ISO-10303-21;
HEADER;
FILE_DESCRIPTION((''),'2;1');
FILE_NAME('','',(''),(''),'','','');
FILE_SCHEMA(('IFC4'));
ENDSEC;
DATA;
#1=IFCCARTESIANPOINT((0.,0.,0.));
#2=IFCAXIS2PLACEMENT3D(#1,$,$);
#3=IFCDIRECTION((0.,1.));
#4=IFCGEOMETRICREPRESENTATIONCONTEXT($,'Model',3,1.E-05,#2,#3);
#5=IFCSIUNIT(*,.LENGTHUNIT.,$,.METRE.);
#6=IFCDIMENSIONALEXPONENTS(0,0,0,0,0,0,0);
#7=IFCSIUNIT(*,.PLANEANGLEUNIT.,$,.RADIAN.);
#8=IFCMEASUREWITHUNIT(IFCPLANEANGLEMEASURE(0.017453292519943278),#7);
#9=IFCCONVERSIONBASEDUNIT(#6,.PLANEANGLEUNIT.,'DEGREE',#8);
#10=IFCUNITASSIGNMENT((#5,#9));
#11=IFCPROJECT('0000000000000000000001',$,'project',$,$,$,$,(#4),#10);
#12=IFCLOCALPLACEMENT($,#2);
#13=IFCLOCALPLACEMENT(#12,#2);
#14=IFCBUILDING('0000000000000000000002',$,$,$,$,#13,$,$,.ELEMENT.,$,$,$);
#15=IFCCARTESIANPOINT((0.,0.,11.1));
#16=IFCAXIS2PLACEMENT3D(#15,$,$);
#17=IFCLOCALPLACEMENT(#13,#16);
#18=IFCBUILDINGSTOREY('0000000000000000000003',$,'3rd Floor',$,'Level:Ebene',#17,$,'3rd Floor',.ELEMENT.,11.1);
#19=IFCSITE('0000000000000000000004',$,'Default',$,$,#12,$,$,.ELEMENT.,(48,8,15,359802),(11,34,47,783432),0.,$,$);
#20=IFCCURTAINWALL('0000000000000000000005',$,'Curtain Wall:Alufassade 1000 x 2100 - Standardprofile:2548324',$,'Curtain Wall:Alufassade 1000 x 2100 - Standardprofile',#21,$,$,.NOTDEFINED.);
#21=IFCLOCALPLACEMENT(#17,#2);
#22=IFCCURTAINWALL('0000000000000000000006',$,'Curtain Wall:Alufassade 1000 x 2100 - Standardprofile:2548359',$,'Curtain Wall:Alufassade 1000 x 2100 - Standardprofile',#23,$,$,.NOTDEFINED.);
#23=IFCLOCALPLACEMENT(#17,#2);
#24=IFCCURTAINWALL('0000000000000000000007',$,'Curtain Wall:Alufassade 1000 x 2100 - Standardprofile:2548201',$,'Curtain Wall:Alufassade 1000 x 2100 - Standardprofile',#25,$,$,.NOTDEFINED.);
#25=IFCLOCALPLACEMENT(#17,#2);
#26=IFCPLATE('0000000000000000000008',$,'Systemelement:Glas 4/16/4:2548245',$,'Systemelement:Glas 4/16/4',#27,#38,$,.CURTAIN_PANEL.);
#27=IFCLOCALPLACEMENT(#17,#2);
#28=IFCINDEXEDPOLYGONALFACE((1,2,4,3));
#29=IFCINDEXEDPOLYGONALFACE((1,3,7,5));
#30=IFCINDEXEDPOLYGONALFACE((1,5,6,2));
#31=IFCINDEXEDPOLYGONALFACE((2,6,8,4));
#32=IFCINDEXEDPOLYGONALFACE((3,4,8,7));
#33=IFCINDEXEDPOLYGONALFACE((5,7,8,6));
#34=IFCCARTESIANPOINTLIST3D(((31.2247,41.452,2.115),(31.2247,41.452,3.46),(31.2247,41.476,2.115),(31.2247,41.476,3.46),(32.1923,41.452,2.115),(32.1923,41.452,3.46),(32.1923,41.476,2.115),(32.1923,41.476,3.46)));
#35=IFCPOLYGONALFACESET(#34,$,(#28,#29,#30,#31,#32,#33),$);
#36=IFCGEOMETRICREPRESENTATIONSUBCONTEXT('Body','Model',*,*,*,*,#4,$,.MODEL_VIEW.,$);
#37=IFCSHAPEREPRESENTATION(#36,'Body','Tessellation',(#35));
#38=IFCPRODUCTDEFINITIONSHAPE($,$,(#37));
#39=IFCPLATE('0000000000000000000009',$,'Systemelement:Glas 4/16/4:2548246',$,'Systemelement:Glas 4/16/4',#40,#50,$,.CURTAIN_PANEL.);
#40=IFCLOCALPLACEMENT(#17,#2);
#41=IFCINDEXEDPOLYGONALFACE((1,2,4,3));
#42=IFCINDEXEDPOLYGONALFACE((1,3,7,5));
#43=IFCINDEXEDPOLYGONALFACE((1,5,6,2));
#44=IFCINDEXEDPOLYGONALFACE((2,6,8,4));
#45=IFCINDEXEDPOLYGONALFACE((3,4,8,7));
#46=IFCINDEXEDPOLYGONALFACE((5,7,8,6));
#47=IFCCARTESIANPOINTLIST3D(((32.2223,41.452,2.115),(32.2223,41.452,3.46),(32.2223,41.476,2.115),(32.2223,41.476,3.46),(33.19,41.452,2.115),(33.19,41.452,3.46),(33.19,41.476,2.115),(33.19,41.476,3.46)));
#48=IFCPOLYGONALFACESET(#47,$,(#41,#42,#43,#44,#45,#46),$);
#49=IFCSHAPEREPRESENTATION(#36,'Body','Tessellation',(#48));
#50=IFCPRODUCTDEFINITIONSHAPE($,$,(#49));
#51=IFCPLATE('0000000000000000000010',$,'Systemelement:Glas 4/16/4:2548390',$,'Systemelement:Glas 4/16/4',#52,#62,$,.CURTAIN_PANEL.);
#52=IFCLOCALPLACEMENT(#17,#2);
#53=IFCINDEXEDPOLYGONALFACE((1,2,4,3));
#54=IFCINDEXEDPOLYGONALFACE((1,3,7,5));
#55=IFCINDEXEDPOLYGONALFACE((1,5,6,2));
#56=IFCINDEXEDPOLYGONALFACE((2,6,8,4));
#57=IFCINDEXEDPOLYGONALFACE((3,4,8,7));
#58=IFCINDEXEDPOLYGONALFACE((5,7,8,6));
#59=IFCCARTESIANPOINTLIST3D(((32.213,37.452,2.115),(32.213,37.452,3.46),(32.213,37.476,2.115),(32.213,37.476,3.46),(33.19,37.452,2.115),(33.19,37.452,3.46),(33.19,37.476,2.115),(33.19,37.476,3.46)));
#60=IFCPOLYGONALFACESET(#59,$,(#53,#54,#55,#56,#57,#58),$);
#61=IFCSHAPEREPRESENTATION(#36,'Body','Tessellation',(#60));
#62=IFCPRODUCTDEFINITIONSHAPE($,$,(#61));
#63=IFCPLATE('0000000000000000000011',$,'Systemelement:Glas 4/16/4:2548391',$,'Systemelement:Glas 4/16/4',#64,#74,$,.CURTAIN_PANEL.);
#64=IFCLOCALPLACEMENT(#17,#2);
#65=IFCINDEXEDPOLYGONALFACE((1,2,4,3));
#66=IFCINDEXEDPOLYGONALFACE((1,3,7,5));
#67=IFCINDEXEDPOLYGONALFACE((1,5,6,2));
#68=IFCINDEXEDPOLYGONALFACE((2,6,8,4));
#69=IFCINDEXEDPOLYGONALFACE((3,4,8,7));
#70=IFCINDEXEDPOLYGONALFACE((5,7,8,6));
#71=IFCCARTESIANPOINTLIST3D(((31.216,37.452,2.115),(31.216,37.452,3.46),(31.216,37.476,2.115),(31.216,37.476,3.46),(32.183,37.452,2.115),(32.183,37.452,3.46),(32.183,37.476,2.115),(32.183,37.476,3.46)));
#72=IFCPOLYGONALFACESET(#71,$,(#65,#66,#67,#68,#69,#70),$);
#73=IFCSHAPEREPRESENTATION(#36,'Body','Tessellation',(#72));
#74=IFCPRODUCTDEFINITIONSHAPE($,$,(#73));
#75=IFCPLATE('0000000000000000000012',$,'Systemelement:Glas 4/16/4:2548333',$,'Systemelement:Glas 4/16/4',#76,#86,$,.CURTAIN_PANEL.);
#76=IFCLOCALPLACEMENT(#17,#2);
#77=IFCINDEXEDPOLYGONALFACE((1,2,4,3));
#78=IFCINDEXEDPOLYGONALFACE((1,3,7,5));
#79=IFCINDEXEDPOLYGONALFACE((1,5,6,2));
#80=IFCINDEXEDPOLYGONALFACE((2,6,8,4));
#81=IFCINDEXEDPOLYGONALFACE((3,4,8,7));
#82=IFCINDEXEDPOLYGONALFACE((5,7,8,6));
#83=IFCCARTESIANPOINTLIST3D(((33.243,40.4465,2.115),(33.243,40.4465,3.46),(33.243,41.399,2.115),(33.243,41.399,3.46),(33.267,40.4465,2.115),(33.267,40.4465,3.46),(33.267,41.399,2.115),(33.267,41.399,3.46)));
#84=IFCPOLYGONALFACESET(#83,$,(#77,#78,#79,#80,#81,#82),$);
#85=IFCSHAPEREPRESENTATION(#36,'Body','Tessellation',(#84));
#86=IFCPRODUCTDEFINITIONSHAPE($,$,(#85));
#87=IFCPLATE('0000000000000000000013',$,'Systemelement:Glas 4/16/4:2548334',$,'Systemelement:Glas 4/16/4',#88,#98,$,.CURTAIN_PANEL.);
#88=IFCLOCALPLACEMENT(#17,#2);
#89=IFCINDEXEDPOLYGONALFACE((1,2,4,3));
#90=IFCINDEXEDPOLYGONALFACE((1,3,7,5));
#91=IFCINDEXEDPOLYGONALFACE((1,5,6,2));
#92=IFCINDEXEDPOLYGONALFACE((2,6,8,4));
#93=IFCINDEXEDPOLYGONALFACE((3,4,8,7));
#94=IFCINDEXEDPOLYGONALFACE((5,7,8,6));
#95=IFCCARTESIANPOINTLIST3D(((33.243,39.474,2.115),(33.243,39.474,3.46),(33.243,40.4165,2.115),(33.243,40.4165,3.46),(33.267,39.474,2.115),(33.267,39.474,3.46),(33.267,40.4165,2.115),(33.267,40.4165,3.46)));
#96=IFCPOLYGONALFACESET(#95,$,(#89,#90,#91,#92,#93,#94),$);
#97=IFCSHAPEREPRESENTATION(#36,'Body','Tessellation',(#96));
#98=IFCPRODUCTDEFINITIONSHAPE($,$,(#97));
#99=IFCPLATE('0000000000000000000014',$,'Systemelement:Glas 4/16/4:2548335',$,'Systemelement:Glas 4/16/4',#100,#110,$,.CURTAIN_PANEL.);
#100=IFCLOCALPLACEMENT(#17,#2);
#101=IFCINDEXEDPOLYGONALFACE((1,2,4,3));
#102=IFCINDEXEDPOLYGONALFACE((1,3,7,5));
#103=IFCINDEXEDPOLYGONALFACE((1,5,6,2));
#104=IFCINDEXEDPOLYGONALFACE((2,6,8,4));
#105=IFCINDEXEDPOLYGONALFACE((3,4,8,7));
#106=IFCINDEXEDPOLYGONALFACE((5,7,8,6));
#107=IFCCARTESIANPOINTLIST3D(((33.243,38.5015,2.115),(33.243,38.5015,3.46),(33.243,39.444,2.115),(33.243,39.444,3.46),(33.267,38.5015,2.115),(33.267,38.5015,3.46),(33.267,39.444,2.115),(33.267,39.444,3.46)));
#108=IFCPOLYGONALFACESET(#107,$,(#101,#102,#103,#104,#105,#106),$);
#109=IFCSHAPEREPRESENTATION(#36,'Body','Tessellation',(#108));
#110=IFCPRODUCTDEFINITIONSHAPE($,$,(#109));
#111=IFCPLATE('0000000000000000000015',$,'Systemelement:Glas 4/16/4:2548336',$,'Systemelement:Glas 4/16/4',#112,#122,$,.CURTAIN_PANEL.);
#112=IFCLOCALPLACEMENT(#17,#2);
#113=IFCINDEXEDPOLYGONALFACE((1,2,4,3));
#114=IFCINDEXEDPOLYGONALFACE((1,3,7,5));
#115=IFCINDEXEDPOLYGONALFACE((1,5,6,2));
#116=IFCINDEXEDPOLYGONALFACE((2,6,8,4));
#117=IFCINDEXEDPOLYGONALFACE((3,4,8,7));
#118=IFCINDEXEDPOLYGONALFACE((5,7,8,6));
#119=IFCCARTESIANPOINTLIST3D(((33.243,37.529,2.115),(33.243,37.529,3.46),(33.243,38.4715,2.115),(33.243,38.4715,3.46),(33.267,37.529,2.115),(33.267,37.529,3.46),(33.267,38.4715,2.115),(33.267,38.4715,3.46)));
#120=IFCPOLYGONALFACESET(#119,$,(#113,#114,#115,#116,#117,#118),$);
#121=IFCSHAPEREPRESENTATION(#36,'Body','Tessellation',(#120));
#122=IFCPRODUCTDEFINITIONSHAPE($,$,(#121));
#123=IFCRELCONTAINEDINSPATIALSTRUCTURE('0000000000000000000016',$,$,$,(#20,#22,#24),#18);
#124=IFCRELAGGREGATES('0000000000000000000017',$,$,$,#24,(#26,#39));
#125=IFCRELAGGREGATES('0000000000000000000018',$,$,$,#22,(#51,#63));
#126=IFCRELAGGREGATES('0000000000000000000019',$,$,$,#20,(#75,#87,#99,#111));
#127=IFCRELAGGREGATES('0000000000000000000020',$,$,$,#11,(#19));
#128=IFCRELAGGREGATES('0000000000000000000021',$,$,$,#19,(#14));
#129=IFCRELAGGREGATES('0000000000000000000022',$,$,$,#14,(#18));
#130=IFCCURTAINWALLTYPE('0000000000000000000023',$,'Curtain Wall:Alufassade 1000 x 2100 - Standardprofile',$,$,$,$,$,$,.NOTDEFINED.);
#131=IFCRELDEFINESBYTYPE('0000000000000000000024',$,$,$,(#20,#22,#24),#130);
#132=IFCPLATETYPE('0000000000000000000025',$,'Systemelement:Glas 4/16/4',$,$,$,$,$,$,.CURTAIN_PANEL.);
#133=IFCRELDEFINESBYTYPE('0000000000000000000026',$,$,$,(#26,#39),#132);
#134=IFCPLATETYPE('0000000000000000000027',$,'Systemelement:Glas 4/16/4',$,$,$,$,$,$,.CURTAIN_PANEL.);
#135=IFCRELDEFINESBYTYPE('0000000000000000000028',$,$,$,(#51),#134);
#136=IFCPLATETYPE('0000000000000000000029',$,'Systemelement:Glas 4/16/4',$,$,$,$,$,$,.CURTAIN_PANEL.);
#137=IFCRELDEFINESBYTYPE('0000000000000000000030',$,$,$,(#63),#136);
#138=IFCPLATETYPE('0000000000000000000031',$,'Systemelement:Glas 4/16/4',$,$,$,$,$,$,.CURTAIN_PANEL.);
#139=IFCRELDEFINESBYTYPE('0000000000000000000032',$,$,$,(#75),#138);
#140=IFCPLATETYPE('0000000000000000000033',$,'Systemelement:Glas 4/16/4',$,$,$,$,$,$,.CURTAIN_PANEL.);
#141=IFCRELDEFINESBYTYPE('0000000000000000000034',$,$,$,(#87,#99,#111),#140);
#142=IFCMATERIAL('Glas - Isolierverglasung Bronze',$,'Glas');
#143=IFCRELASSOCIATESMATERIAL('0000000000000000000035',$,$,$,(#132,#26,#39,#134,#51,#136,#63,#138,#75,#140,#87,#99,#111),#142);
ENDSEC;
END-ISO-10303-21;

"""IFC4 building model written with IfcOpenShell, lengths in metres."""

from ifc_helpers import new_model, entity, si_unit, converted_unit, direction, frame, origin, place, context, subcontext, project, spatial, indexed_curve, outline, extrude, source, transform, mapped, material, type_object, type_shapes, element, aggregate, save


model = new_model("IFC4")

# Units and contexts
model_context = context("Model", 3, precision=1e-05, world=origin(), true_north=direction((0.0, 1.0)))
body_context = subcontext(model_context, "Body", "Model", "MODEL_VIEW")
ifc_project = project(units=[si_unit("LENGTHUNIT", "METRE"), converted_unit("PLANEANGLEUNIT", "DEGREE", entity("IfcPlaneAngleMeasure", 0.017453292519943278), si_unit("PLANEANGLEUNIT", "RADIAN"), dimensions=[0, 0, 0, 0, 0, 0, 0])], contexts=[model_context])

# Site, building, storey
site_placement = place(None, origin())
site = spatial("IfcSite", under=ifc_project, at=site_placement, Name="Default", CompositionType="ELEMENT", RefLatitude=(48, 8, 15, 359802), RefLongitude=(11, 34, 47, 783432), RefElevation=0.0)
building_placement = place(site_placement, origin())
building = spatial("IfcBuilding", under=site, at=building_placement, CompositionType="ELEMENT")
storey_placement = place(building_placement, frame((0.0, 0.0, 11.1)))
storey = spatial("IfcBuildingStorey", under=building, at=storey_placement, Name="3rd Floor", ObjectType="Level:Ebene", LongName="3rd Floor", CompositionType="ELEMENT", Elevation=11.1)

# Curtain walls
curtain_wall_type = type_object("IfcCurtainWallType", Name="Curtain Wall:Alufassade 1000 x 2100 - Standardprofile", PredefinedType="NOTDEFINED")
curtain_wall_1_placement = place(storey_placement, frame((0.0, 0.0, -11.1)))
curtain_wall_1 = element("IfcCurtainWall", 1, at=curtain_wall_1_placement, inside=storey, type_object=curtain_wall_type, Name="Curtain Wall:Alufassade 1000 x 2100 - Standardprofile:2548324", ObjectType="Curtain Wall:Alufassade 1000 x 2100 - Standardprofile", PredefinedType="NOTDEFINED")
curtain_wall_2_placement = place(storey_placement, frame((0.0, 0.0, -11.1)))
curtain_wall_2 = element("IfcCurtainWall", 2, at=curtain_wall_2_placement, inside=storey, type_object=curtain_wall_type, Name="Curtain Wall:Alufassade 1000 x 2100 - Standardprofile:2548359", ObjectType="Curtain Wall:Alufassade 1000 x 2100 - Standardprofile", PredefinedType="NOTDEFINED")

# Curtain wall
curtain_wall_3_placement = place(storey_placement, frame((0.0, 0.0, -11.1)))
curtain_wall_3 = element("IfcCurtainWall", 3, at=curtain_wall_3_placement, inside=storey, type_object=curtain_wall_type, Name="Curtain Wall:Alufassade 1000 x 2100 - Standardprofile:2548201", ObjectType="Curtain Wall:Alufassade 1000 x 2100 - Standardprofile", PredefinedType="NOTDEFINED")

# Plates
ifc_material_1 = material(Name="Glas - Isolierverglasung Bronze", Category="Glas")
plate_type_1 = type_object("IfcPlateType", Name="Systemelement:Glas 4/16/4", PredefinedType="CURTAIN_PANEL", material=ifc_material_1)
shared_shape_1 = source(origin(), body_context, "Body", "SweptSolid", [
    extrude(outline(indexed_curve([(-0.012, -0.4838), (0.012, -0.4838), (0.012, 0.4838), (-0.012, 0.4838), (-0.012, -0.4838)], self_intersect=False)), frame((0.0, 0.0, 0.0), z_axis=(0.0, 0.0, 1.0), x_axis=(0.0, 1.0, 0.0)), (0.0, 0.0, 1.0), 1.345),
])
type_shapes(plate_type_1, [shared_shape_1])
plate_1_placement = place(curtain_wall_3_placement, frame((31.7085, 41.464, 13.215)))
plate_1 = element("IfcPlate", 4, at=plate_1_placement, type_object=plate_type_1, material=ifc_material_1, Name="Systemelement:Glas 4/16/4:2548245", ObjectType="Systemelement:Glas 4/16/4", PredefinedType="CURTAIN_PANEL", context=body_context, shape_type="MappedRepresentation", body=[
    mapped(shared_shape_1, transform((0.0, 0.0, 0.0), scale=1.0)),
])
plate_2_placement = place(curtain_wall_3_placement, frame((32.7062, 41.464, 13.215)))
plate_2 = element("IfcPlate", 5, at=plate_2_placement, type_object=plate_type_1, material=ifc_material_1, Name="Systemelement:Glas 4/16/4:2548246", ObjectType="Systemelement:Glas 4/16/4", PredefinedType="CURTAIN_PANEL", context=body_context, shape_type="MappedRepresentation", body=[
    mapped(shared_shape_1, transform((0.0, 0.0, 0.0), scale=1.0)),
])
aggregate(curtain_wall_3, [plate_1, plate_2])
plate_type_2 = type_object("IfcPlateType", Name="Systemelement:Glas 4/16/4", PredefinedType="CURTAIN_PANEL", material=ifc_material_1)
shared_shape_2 = source(origin(), body_context, "Body", "SweptSolid", [
    extrude(outline(indexed_curve([(-0.012, -0.4885), (0.012, -0.4885), (0.012, 0.4885), (-0.012, 0.4885), (-0.012, -0.4885)], self_intersect=False)), frame((0.0, 0.0, 0.0), z_axis=(0.0, 0.0, 1.0), x_axis=(0.0, 1.0, 0.0)), (0.0, 0.0, 1.0), 1.345),
])
type_shapes(plate_type_2, [shared_shape_2])
plate_3_placement = place(curtain_wall_2_placement, frame((32.7015, 37.464, 13.215), z_axis=(0.0, 0.0, 1.0), x_axis=(-1.0, 0.0, 0.0)))
plate_3 = element("IfcPlate", 6, at=plate_3_placement, type_object=plate_type_2, material=ifc_material_1, Name="Systemelement:Glas 4/16/4:2548390", ObjectType="Systemelement:Glas 4/16/4", PredefinedType="CURTAIN_PANEL", context=body_context, shape_type="MappedRepresentation", body=[
    mapped(shared_shape_2, transform((0.0, 0.0, 0.0), scale=1.0)),
])
plate_type_3 = type_object("IfcPlateType", Name="Systemelement:Glas 4/16/4", PredefinedType="CURTAIN_PANEL", material=ifc_material_1)
shared_shape_3 = source(origin(), body_context, "Body", "SweptSolid", [
    extrude(outline(indexed_curve([(-0.012, -0.4835), (0.012, -0.4835), (0.012, 0.4835), (-0.012, 0.4835), (-0.012, -0.4835)], self_intersect=False)), frame((0.0, 0.0, 0.0), z_axis=(0.0, 0.0, 1.0), x_axis=(0.0, 1.0, 0.0)), (0.0, 0.0, 1.0), 1.345),
])
type_shapes(plate_type_3, [shared_shape_3])
plate_4_placement = place(curtain_wall_2_placement, frame((31.6995, 37.464, 13.215), z_axis=(0.0, 0.0, 1.0), x_axis=(-1.0, 0.0, 0.0)))
plate_4 = element("IfcPlate", 7, at=plate_4_placement, type_object=plate_type_3, material=ifc_material_1, Name="Systemelement:Glas 4/16/4:2548391", ObjectType="Systemelement:Glas 4/16/4", PredefinedType="CURTAIN_PANEL", context=body_context, shape_type="MappedRepresentation", body=[
    mapped(shared_shape_3, transform((0.0, 0.0, 0.0), scale=1.0)),
])
aggregate(curtain_wall_2, [plate_3, plate_4])
plate_type_4 = type_object("IfcPlateType", Name="Systemelement:Glas 4/16/4", PredefinedType="CURTAIN_PANEL", material=ifc_material_1)
shared_shape_4 = source(origin(), body_context, "Body", "SweptSolid", [
    extrude(outline(indexed_curve([(-0.012, -0.4763), (0.012, -0.4763), (0.012, 0.4763), (-0.012, 0.4763), (-0.012, -0.4763)], self_intersect=False)), frame((0.0, 0.0, 0.0), z_axis=(0.0, 0.0, 1.0), x_axis=(0.0, 1.0, 0.0)), (0.0, 0.0, 1.0), 1.345),
])
type_shapes(plate_type_4, [shared_shape_4])
plate_5_placement = place(curtain_wall_1_placement, frame((33.255, 40.9228, 13.215), z_axis=(0.0, 0.0, 1.0), x_axis=(0.0, -1.0, 0.0)))
plate_5 = element("IfcPlate", 8, at=plate_5_placement, type_object=plate_type_4, material=ifc_material_1, Name="Systemelement:Glas 4/16/4:2548333", ObjectType="Systemelement:Glas 4/16/4", PredefinedType="CURTAIN_PANEL", context=body_context, shape_type="MappedRepresentation", body=[
    mapped(shared_shape_4, transform((0.0, 0.0, 0.0), scale=1.0)),
])
plate_type_5 = type_object("IfcPlateType", Name="Systemelement:Glas 4/16/4", PredefinedType="CURTAIN_PANEL", material=ifc_material_1)
shared_shape_5 = source(origin(), body_context, "Body", "SweptSolid", [
    extrude(outline(indexed_curve([(-0.012, -0.4712), (0.012, -0.4712), (0.012, 0.4712), (-0.012, 0.4712), (-0.012, -0.4712)], self_intersect=False)), frame((0.0, 0.0, 0.0), z_axis=(0.0, 0.0, 1.0), x_axis=(0.0, 1.0, 0.0)), (0.0, 0.0, 1.0), 1.345),
])
type_shapes(plate_type_5, [shared_shape_5])
plate_6_placement = place(curtain_wall_1_placement, frame((33.255, 39.9453, 13.215), z_axis=(0.0, 0.0, 1.0), x_axis=(0.0, -1.0, 0.0)))
plate_6 = element("IfcPlate", 9, at=plate_6_placement, type_object=plate_type_5, material=ifc_material_1, Name="Systemelement:Glas 4/16/4:2548334", ObjectType="Systemelement:Glas 4/16/4", PredefinedType="CURTAIN_PANEL", context=body_context, shape_type="MappedRepresentation", body=[
    mapped(shared_shape_5, transform((0.0, 0.0, 0.0), scale=1.0)),
])
plate_7_placement = place(curtain_wall_1_placement, frame((33.255, 38.9728, 13.215), z_axis=(0.0, 0.0, 1.0), x_axis=(0.0, -1.0, 0.0)))
plate_7 = element("IfcPlate", 10, at=plate_7_placement, type_object=plate_type_5, material=ifc_material_1, Name="Systemelement:Glas 4/16/4:2548335", ObjectType="Systemelement:Glas 4/16/4", PredefinedType="CURTAIN_PANEL", context=body_context, shape_type="MappedRepresentation", body=[
    mapped(shared_shape_5, transform((0.0, 0.0, 0.0), scale=1.0)),
])
plate_8_placement = place(curtain_wall_1_placement, frame((33.255, 38.0003, 13.215), z_axis=(0.0, 0.0, 1.0), x_axis=(0.0, -1.0, 0.0)))
plate_8 = element("IfcPlate", 11, at=plate_8_placement, type_object=plate_type_5, material=ifc_material_1, Name="Systemelement:Glas 4/16/4:2548336", ObjectType="Systemelement:Glas 4/16/4", PredefinedType="CURTAIN_PANEL", context=body_context, shape_type="MappedRepresentation", body=[
    mapped(shared_shape_5, transform((0.0, 0.0, 0.0), scale=1.0)),
])
aggregate(curtain_wall_1, [plate_5, plate_6, plate_7, plate_8])

save(model, "model.ifc")
